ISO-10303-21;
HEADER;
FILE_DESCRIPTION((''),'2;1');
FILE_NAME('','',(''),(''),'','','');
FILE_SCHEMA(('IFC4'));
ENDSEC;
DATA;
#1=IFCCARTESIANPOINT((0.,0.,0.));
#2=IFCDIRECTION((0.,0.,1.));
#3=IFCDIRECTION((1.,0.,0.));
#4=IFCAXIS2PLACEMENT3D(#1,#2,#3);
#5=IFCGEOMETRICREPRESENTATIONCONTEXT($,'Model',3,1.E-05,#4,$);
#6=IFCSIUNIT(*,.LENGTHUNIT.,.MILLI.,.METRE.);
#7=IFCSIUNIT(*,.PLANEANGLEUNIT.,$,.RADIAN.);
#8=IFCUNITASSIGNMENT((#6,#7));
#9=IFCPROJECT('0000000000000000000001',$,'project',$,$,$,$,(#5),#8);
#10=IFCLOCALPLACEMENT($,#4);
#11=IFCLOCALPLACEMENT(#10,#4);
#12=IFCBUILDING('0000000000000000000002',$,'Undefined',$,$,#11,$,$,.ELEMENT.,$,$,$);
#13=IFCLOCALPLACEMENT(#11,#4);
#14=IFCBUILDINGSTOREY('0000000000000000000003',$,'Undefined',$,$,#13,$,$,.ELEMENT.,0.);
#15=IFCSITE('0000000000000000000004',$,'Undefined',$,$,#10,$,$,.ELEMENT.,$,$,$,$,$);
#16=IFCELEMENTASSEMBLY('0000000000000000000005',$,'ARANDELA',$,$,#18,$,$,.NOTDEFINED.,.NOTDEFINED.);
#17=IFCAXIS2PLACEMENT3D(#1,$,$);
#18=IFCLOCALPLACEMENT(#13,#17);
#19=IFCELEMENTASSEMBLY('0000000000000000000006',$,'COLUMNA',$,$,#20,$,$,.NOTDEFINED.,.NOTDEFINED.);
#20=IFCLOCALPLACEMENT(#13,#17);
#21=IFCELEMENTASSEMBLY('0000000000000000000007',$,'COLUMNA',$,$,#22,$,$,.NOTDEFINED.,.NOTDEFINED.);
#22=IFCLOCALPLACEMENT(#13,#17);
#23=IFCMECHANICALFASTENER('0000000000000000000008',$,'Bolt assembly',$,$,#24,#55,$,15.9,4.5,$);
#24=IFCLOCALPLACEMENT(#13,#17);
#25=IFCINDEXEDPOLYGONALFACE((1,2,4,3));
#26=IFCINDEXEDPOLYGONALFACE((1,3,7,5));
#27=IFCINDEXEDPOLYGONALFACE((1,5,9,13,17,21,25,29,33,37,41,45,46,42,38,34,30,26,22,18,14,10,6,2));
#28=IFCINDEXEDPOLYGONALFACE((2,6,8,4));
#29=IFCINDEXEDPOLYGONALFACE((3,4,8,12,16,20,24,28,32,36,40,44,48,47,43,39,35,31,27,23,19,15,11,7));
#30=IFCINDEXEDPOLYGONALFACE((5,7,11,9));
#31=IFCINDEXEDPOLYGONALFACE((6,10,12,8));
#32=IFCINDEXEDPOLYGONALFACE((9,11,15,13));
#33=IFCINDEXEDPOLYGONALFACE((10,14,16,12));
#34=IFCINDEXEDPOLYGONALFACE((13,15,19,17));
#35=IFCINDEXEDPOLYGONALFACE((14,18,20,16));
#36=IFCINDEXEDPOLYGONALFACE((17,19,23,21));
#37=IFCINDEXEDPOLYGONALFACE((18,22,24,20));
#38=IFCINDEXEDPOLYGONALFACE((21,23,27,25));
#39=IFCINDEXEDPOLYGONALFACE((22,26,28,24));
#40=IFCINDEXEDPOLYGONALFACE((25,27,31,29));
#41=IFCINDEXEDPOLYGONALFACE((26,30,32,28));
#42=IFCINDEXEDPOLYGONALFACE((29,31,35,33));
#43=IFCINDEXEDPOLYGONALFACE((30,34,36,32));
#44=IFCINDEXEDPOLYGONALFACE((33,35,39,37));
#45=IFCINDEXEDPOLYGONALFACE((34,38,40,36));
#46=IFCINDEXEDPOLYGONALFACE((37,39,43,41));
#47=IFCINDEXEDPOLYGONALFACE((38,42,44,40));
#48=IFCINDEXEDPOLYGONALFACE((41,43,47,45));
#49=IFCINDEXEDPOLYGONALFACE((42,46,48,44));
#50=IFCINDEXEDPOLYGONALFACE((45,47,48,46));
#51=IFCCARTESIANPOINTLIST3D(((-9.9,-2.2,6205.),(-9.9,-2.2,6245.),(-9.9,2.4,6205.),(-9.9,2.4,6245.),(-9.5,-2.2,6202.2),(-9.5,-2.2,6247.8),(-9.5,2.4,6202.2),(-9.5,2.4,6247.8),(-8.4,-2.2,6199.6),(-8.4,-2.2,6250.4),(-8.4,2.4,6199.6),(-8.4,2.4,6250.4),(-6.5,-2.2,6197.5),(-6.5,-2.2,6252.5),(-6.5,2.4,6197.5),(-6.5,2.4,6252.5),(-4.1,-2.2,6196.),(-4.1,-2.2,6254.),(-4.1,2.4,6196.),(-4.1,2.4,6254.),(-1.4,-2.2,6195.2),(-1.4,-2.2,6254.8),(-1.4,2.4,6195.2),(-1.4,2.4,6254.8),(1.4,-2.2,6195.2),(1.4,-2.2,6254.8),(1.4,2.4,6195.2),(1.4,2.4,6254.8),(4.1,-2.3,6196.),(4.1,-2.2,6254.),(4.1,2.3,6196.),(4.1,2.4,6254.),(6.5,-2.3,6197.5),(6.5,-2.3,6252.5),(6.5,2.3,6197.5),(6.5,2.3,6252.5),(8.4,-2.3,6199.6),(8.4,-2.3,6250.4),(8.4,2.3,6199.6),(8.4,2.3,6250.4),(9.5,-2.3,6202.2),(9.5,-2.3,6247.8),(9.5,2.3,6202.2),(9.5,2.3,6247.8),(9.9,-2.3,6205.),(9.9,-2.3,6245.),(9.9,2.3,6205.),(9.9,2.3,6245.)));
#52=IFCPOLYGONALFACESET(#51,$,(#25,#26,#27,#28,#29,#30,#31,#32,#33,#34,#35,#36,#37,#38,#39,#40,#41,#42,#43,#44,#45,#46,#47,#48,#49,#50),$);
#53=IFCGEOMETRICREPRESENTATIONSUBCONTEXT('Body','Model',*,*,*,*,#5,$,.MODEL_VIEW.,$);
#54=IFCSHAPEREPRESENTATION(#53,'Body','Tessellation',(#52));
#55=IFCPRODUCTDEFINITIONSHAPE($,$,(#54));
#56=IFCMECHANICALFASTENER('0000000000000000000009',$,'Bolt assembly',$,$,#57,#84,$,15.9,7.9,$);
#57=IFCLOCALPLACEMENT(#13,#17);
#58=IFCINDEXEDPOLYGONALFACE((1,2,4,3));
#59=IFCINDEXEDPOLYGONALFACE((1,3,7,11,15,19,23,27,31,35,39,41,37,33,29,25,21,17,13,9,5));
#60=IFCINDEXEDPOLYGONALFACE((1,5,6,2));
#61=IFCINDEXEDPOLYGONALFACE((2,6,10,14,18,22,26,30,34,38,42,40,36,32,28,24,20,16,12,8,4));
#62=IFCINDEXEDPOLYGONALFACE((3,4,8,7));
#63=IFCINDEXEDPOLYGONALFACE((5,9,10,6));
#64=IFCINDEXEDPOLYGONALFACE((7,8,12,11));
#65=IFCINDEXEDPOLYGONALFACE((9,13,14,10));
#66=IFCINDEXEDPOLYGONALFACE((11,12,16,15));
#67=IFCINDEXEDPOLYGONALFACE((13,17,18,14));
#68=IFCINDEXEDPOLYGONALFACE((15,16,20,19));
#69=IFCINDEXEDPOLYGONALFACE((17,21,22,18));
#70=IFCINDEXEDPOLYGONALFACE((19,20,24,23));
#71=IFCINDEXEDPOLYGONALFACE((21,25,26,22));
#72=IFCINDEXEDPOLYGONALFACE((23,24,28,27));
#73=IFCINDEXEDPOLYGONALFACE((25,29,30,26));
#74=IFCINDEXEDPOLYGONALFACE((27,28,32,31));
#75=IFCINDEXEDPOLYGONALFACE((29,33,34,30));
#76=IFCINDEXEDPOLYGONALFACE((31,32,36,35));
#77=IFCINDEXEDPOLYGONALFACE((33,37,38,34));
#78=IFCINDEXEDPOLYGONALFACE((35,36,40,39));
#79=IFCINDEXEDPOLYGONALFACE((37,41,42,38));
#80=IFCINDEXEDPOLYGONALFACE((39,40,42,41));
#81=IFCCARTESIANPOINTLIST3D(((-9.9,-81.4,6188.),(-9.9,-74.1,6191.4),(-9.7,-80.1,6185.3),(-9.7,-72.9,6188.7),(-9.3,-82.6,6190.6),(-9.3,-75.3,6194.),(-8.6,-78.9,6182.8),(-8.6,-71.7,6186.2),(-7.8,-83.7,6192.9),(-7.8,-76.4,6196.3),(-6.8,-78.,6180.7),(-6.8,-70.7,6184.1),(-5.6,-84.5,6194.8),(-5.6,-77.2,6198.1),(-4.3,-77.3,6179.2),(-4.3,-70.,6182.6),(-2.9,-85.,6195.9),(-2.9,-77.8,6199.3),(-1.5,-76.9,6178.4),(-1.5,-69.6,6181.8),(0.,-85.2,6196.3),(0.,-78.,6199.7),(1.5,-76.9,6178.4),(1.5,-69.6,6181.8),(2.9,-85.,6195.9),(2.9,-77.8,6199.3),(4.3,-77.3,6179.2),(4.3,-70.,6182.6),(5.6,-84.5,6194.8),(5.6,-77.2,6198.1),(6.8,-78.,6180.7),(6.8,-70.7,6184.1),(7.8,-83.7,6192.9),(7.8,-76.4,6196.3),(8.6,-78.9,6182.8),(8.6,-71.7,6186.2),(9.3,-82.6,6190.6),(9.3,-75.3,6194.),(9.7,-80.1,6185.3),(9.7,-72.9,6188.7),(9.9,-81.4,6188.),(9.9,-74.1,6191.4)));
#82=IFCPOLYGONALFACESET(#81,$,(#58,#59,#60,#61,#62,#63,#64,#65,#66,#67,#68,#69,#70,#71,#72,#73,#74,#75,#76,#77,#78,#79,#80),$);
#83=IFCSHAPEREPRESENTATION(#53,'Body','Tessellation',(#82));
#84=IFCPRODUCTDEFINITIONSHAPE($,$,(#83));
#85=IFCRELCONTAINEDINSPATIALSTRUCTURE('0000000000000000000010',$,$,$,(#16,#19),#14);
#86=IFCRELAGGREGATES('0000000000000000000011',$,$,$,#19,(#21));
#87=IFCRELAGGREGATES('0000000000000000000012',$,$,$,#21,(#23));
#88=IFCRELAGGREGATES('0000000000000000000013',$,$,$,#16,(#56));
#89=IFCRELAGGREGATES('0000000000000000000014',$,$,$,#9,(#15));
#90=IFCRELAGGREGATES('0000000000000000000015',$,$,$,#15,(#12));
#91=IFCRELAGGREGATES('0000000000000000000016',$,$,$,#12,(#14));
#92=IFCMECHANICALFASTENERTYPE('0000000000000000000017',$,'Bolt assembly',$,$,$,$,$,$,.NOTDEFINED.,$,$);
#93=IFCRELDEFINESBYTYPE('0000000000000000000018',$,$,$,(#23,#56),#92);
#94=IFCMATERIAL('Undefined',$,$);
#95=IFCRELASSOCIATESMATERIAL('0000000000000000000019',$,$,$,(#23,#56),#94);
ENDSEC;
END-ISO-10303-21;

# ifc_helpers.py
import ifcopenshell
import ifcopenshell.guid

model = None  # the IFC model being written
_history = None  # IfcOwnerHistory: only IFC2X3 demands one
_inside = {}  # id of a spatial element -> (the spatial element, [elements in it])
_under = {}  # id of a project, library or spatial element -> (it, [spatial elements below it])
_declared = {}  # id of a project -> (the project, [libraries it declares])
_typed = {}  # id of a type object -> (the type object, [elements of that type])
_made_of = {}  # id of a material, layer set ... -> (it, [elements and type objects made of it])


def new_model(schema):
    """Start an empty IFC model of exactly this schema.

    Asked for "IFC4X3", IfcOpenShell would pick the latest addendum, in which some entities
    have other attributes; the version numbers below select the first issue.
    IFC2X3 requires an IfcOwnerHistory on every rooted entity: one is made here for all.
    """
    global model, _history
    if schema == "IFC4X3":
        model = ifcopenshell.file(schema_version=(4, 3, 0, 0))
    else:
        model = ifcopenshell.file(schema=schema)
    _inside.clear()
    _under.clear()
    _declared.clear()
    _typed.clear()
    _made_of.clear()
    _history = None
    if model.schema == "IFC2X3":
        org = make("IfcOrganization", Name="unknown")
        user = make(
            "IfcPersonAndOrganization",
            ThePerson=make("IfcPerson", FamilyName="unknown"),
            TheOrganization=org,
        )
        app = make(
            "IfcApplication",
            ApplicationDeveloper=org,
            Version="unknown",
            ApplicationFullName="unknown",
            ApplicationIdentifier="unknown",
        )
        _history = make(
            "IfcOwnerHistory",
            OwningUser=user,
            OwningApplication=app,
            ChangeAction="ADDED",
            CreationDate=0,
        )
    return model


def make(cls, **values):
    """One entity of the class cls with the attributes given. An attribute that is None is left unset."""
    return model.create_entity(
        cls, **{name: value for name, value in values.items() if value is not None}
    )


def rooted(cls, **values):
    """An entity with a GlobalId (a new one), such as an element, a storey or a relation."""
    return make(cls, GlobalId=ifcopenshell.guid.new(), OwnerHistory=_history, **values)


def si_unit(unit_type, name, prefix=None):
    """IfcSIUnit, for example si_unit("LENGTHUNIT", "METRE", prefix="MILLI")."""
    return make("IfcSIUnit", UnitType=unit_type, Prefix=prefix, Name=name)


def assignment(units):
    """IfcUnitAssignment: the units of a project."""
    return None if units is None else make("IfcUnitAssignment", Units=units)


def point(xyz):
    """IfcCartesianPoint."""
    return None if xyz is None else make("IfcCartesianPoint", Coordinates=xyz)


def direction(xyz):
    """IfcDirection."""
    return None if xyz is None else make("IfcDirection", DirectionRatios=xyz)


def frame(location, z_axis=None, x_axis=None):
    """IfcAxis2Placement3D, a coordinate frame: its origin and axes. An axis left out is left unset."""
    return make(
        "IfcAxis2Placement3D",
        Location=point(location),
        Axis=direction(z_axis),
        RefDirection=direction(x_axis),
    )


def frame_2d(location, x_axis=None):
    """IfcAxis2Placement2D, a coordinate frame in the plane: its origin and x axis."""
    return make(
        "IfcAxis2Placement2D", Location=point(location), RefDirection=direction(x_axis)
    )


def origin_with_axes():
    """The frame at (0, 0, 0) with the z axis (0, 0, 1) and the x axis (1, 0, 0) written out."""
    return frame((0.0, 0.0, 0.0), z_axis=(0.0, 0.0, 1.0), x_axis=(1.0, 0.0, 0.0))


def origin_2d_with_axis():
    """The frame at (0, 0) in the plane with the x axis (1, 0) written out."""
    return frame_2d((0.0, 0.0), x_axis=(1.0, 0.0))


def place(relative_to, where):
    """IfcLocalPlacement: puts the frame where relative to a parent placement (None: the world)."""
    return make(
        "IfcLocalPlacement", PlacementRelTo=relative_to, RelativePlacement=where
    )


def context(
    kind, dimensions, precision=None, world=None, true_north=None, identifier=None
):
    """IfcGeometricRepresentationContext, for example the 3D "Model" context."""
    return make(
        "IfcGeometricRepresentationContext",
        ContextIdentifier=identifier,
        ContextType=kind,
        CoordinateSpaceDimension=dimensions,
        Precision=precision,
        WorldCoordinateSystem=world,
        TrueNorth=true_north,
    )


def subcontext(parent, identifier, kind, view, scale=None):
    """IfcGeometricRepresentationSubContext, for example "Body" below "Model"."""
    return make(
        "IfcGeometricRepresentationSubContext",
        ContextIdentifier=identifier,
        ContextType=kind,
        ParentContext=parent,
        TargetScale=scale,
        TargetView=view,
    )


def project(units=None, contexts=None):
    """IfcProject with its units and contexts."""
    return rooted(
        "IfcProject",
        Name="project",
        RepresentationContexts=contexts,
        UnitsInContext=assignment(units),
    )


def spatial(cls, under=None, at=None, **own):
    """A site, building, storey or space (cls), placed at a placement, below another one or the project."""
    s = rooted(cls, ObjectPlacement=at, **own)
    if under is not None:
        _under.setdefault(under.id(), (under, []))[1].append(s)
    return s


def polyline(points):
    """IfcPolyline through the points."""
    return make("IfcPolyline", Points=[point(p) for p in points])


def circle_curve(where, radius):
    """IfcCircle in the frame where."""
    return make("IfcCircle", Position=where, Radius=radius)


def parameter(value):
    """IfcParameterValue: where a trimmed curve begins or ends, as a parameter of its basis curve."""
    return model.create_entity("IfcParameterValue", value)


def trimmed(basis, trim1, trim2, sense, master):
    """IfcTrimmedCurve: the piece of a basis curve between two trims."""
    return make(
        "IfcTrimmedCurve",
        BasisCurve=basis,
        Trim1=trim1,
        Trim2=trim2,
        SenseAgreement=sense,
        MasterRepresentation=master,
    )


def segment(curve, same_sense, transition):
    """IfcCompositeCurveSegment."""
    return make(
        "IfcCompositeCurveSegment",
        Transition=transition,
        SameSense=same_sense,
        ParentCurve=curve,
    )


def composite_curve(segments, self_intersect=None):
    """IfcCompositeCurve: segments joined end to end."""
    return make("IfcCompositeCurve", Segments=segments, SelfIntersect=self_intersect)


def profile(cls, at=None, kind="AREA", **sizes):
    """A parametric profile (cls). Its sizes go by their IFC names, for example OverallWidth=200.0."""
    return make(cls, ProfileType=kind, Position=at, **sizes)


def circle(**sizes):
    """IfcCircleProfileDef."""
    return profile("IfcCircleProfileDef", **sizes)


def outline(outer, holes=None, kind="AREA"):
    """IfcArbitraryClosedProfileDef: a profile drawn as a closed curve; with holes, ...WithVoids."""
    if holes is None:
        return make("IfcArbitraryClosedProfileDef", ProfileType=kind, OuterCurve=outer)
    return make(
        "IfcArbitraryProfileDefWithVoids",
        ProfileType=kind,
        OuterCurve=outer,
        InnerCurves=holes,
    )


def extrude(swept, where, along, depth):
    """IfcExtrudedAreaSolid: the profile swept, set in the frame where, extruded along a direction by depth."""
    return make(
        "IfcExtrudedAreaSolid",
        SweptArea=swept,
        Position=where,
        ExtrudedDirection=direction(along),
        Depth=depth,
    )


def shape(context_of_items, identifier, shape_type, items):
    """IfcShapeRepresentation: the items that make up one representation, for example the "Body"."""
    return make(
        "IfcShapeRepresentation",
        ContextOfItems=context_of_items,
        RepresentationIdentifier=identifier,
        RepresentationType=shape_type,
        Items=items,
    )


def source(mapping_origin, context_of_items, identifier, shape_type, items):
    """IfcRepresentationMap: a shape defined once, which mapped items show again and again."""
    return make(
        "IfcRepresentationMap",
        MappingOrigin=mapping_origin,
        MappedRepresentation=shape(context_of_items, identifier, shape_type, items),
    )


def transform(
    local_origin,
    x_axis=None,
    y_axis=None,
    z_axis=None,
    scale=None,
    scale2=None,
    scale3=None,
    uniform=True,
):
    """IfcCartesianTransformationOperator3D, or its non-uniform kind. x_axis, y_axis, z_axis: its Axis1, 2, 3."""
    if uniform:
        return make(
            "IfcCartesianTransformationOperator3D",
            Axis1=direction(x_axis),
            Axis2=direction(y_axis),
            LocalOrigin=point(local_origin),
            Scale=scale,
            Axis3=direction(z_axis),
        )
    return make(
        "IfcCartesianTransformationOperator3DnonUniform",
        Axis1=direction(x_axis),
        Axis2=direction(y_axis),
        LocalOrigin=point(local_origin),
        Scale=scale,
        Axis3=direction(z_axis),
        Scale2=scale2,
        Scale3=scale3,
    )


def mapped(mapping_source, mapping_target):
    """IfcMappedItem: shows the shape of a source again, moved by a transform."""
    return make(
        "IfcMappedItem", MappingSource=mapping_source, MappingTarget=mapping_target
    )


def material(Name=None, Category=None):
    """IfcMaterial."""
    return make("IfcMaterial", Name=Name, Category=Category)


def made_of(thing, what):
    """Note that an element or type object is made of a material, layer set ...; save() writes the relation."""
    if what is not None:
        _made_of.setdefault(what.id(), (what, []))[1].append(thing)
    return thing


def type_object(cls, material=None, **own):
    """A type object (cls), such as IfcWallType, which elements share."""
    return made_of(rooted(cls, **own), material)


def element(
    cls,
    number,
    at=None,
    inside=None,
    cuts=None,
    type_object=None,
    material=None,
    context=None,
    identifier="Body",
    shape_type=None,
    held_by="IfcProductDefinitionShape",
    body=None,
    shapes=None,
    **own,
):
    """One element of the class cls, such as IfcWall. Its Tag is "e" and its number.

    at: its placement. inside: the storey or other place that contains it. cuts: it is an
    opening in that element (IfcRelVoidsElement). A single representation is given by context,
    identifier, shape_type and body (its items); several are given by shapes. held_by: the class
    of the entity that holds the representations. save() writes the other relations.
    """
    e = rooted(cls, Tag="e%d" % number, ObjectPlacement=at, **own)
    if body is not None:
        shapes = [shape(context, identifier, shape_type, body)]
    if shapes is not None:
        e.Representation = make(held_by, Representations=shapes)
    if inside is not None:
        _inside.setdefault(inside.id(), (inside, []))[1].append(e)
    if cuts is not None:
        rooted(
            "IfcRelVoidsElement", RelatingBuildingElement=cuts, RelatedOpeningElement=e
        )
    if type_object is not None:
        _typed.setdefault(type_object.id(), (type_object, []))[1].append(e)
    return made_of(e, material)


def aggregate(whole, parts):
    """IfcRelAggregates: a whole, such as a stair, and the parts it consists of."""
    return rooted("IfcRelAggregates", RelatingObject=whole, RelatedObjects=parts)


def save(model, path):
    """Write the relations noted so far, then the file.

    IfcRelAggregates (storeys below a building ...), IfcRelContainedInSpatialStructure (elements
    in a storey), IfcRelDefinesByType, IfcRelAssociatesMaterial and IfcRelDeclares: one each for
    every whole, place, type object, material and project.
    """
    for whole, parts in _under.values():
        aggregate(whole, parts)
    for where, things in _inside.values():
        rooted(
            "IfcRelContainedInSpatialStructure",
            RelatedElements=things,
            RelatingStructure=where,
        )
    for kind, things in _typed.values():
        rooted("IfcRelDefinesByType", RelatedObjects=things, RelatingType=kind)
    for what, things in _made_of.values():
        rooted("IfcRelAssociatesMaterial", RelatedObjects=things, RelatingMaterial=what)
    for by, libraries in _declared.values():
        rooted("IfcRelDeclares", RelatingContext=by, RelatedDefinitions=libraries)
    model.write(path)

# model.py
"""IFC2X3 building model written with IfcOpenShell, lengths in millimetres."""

from ifc_helpers import new_model, si_unit, frame, frame_2d, origin_with_axes, origin_2d_with_axis, place, context, subcontext, project, spatial, polyline, circle_curve, parameter, trimmed, segment, composite_curve, circle, outline, extrude, source, transform, mapped, material, type_object, element, aggregate, save


model = new_model("IFC2X3")

# Units and contexts
model_context = context("Model", 3, precision=1e-05, world=origin_with_axes())
body_context = subcontext(model_context, "Body", "Model", "MODEL_VIEW")
ifc_project = project(units=[si_unit("LENGTHUNIT", "METRE", prefix="MILLI"), si_unit("PLANEANGLEUNIT", "RADIAN")], contexts=[model_context])

# Site, building, storey
site_placement = place(None, origin_with_axes())
site = spatial("IfcSite", under=ifc_project, at=site_placement, Name="Undefined", CompositionType="ELEMENT")
building_placement = place(site_placement, origin_with_axes())
building = spatial("IfcBuilding", under=site, at=building_placement, Name="Undefined", CompositionType="ELEMENT")
storey_placement = place(building_placement, origin_with_axes())
storey = spatial("IfcBuildingStorey", under=building, at=storey_placement, Name="Undefined", CompositionType="ELEMENT", Elevation=0.0)

# Element assembly
assembly_1_placement = place(storey_placement, origin_with_axes())
assembly_1 = element("IfcElementAssembly", 1, at=assembly_1_placement, inside=storey, Name="ARANDELA", AssemblyPlace="NOTDEFINED", PredefinedType="NOTDEFINED")

# Element assembly
assembly_2_placement = place(storey_placement, origin_with_axes())
assembly_2 = element("IfcElementAssembly", 2, at=assembly_2_placement, inside=storey, Name="COLUMNA", AssemblyPlace="NOTDEFINED", PredefinedType="NOTDEFINED")

# Shared definitions
ifc_material_1 = material(Name="Undefined")
mechanical_fastener_type = type_object("IfcMechanicalFastenerType", Name="Bolt assembly")

# Element assembly
assembly_3_placement = place(assembly_2_placement, origin_with_axes())
assembly_3 = element("IfcElementAssembly", 3, at=assembly_3_placement, Name="COLUMNA", AssemblyPlace="NOTDEFINED", PredefinedType="NOTDEFINED")
aggregate(assembly_2, [assembly_3])

# Mechanical fasteners
shared_shape_1 = source(origin_with_axes(), body_context, "Body", "SweptSolid", [
    extrude(outline(composite_curve([segment(polyline([(-20.0, 9.9), (20.0, 9.9)]), True, "CONTINUOUS"), segment(trimmed(circle_curve(frame_2d((20.0, 0.0), x_axis=(0.0, 1.0)), 9.9), [parameter(0.0)], [parameter(3.141593)], False, "PARAMETER"), True, "CONTINUOUS"), segment(polyline([(20.0, -9.9), (-20.0, -9.9)]), True, "CONTINUOUS"), segment(trimmed(circle_curve(frame_2d((-20.0, 0.0), x_axis=(0.0, -1.0)), 9.9), [parameter(0.0)], [parameter(3.141593)], False, "PARAMETER"), True, "DISCONTINUOUS")], self_intersect=False)), frame((0.0, -2.2, 0.0), z_axis=(0.0, 1.0, 0.0), x_axis=(1.0, 0.0, 0.0)), (0.0, 0.0, 1.0), 4.6),
])
mechanical_fastener_1_placement = place(assembly_3_placement, frame((0.0, 0.0, 6225.0), z_axis=(-1.0, 0.000001, 0.000269), x_axis=(0.000269, 0.0, 1.0)))
mechanical_fastener_1 = element("IfcMechanicalFastener", 4, at=mechanical_fastener_1_placement, type_object=mechanical_fastener_type, material=ifc_material_1, Name="Bolt assembly", NominalDiameter=15.9, NominalLength=4.5, context=body_context, shape_type="MappedRepresentation", body=[
    mapped(shared_shape_1, transform((0.0, 0.0, 0.0))),
])
aggregate(assembly_3, [mechanical_fastener_1])
shared_shape_2 = source(origin_with_axes(), body_context, "Body", "SweptSolid", [
    extrude(circle(Radius=9.9, at=origin_2d_with_axis()), frame((0.0, 0.0, 0.0), z_axis=(0.0, 1.0, 0.0), x_axis=(1.0, 0.0, 0.0)), (0.0, 0.0, 1.0), 8.0),
])
mechanical_fastener_2_placement = place(assembly_1_placement, frame((0.0, -81.0, 6187.3), z_axis=(-1.0, 0.000002, -0.000001), x_axis=(-0.000002, -0.421646, 0.90676)))
mechanical_fastener_2 = element("IfcMechanicalFastener", 5, at=mechanical_fastener_2_placement, type_object=mechanical_fastener_type, material=ifc_material_1, Name="Bolt assembly", NominalDiameter=15.9, NominalLength=7.9, context=body_context, shape_type="MappedRepresentation", body=[
    mapped(shared_shape_2, transform((0.0, 0.0, 0.0))),
])
aggregate(assembly_1, [mechanical_fastener_2])

save(model, "model.ifc")
